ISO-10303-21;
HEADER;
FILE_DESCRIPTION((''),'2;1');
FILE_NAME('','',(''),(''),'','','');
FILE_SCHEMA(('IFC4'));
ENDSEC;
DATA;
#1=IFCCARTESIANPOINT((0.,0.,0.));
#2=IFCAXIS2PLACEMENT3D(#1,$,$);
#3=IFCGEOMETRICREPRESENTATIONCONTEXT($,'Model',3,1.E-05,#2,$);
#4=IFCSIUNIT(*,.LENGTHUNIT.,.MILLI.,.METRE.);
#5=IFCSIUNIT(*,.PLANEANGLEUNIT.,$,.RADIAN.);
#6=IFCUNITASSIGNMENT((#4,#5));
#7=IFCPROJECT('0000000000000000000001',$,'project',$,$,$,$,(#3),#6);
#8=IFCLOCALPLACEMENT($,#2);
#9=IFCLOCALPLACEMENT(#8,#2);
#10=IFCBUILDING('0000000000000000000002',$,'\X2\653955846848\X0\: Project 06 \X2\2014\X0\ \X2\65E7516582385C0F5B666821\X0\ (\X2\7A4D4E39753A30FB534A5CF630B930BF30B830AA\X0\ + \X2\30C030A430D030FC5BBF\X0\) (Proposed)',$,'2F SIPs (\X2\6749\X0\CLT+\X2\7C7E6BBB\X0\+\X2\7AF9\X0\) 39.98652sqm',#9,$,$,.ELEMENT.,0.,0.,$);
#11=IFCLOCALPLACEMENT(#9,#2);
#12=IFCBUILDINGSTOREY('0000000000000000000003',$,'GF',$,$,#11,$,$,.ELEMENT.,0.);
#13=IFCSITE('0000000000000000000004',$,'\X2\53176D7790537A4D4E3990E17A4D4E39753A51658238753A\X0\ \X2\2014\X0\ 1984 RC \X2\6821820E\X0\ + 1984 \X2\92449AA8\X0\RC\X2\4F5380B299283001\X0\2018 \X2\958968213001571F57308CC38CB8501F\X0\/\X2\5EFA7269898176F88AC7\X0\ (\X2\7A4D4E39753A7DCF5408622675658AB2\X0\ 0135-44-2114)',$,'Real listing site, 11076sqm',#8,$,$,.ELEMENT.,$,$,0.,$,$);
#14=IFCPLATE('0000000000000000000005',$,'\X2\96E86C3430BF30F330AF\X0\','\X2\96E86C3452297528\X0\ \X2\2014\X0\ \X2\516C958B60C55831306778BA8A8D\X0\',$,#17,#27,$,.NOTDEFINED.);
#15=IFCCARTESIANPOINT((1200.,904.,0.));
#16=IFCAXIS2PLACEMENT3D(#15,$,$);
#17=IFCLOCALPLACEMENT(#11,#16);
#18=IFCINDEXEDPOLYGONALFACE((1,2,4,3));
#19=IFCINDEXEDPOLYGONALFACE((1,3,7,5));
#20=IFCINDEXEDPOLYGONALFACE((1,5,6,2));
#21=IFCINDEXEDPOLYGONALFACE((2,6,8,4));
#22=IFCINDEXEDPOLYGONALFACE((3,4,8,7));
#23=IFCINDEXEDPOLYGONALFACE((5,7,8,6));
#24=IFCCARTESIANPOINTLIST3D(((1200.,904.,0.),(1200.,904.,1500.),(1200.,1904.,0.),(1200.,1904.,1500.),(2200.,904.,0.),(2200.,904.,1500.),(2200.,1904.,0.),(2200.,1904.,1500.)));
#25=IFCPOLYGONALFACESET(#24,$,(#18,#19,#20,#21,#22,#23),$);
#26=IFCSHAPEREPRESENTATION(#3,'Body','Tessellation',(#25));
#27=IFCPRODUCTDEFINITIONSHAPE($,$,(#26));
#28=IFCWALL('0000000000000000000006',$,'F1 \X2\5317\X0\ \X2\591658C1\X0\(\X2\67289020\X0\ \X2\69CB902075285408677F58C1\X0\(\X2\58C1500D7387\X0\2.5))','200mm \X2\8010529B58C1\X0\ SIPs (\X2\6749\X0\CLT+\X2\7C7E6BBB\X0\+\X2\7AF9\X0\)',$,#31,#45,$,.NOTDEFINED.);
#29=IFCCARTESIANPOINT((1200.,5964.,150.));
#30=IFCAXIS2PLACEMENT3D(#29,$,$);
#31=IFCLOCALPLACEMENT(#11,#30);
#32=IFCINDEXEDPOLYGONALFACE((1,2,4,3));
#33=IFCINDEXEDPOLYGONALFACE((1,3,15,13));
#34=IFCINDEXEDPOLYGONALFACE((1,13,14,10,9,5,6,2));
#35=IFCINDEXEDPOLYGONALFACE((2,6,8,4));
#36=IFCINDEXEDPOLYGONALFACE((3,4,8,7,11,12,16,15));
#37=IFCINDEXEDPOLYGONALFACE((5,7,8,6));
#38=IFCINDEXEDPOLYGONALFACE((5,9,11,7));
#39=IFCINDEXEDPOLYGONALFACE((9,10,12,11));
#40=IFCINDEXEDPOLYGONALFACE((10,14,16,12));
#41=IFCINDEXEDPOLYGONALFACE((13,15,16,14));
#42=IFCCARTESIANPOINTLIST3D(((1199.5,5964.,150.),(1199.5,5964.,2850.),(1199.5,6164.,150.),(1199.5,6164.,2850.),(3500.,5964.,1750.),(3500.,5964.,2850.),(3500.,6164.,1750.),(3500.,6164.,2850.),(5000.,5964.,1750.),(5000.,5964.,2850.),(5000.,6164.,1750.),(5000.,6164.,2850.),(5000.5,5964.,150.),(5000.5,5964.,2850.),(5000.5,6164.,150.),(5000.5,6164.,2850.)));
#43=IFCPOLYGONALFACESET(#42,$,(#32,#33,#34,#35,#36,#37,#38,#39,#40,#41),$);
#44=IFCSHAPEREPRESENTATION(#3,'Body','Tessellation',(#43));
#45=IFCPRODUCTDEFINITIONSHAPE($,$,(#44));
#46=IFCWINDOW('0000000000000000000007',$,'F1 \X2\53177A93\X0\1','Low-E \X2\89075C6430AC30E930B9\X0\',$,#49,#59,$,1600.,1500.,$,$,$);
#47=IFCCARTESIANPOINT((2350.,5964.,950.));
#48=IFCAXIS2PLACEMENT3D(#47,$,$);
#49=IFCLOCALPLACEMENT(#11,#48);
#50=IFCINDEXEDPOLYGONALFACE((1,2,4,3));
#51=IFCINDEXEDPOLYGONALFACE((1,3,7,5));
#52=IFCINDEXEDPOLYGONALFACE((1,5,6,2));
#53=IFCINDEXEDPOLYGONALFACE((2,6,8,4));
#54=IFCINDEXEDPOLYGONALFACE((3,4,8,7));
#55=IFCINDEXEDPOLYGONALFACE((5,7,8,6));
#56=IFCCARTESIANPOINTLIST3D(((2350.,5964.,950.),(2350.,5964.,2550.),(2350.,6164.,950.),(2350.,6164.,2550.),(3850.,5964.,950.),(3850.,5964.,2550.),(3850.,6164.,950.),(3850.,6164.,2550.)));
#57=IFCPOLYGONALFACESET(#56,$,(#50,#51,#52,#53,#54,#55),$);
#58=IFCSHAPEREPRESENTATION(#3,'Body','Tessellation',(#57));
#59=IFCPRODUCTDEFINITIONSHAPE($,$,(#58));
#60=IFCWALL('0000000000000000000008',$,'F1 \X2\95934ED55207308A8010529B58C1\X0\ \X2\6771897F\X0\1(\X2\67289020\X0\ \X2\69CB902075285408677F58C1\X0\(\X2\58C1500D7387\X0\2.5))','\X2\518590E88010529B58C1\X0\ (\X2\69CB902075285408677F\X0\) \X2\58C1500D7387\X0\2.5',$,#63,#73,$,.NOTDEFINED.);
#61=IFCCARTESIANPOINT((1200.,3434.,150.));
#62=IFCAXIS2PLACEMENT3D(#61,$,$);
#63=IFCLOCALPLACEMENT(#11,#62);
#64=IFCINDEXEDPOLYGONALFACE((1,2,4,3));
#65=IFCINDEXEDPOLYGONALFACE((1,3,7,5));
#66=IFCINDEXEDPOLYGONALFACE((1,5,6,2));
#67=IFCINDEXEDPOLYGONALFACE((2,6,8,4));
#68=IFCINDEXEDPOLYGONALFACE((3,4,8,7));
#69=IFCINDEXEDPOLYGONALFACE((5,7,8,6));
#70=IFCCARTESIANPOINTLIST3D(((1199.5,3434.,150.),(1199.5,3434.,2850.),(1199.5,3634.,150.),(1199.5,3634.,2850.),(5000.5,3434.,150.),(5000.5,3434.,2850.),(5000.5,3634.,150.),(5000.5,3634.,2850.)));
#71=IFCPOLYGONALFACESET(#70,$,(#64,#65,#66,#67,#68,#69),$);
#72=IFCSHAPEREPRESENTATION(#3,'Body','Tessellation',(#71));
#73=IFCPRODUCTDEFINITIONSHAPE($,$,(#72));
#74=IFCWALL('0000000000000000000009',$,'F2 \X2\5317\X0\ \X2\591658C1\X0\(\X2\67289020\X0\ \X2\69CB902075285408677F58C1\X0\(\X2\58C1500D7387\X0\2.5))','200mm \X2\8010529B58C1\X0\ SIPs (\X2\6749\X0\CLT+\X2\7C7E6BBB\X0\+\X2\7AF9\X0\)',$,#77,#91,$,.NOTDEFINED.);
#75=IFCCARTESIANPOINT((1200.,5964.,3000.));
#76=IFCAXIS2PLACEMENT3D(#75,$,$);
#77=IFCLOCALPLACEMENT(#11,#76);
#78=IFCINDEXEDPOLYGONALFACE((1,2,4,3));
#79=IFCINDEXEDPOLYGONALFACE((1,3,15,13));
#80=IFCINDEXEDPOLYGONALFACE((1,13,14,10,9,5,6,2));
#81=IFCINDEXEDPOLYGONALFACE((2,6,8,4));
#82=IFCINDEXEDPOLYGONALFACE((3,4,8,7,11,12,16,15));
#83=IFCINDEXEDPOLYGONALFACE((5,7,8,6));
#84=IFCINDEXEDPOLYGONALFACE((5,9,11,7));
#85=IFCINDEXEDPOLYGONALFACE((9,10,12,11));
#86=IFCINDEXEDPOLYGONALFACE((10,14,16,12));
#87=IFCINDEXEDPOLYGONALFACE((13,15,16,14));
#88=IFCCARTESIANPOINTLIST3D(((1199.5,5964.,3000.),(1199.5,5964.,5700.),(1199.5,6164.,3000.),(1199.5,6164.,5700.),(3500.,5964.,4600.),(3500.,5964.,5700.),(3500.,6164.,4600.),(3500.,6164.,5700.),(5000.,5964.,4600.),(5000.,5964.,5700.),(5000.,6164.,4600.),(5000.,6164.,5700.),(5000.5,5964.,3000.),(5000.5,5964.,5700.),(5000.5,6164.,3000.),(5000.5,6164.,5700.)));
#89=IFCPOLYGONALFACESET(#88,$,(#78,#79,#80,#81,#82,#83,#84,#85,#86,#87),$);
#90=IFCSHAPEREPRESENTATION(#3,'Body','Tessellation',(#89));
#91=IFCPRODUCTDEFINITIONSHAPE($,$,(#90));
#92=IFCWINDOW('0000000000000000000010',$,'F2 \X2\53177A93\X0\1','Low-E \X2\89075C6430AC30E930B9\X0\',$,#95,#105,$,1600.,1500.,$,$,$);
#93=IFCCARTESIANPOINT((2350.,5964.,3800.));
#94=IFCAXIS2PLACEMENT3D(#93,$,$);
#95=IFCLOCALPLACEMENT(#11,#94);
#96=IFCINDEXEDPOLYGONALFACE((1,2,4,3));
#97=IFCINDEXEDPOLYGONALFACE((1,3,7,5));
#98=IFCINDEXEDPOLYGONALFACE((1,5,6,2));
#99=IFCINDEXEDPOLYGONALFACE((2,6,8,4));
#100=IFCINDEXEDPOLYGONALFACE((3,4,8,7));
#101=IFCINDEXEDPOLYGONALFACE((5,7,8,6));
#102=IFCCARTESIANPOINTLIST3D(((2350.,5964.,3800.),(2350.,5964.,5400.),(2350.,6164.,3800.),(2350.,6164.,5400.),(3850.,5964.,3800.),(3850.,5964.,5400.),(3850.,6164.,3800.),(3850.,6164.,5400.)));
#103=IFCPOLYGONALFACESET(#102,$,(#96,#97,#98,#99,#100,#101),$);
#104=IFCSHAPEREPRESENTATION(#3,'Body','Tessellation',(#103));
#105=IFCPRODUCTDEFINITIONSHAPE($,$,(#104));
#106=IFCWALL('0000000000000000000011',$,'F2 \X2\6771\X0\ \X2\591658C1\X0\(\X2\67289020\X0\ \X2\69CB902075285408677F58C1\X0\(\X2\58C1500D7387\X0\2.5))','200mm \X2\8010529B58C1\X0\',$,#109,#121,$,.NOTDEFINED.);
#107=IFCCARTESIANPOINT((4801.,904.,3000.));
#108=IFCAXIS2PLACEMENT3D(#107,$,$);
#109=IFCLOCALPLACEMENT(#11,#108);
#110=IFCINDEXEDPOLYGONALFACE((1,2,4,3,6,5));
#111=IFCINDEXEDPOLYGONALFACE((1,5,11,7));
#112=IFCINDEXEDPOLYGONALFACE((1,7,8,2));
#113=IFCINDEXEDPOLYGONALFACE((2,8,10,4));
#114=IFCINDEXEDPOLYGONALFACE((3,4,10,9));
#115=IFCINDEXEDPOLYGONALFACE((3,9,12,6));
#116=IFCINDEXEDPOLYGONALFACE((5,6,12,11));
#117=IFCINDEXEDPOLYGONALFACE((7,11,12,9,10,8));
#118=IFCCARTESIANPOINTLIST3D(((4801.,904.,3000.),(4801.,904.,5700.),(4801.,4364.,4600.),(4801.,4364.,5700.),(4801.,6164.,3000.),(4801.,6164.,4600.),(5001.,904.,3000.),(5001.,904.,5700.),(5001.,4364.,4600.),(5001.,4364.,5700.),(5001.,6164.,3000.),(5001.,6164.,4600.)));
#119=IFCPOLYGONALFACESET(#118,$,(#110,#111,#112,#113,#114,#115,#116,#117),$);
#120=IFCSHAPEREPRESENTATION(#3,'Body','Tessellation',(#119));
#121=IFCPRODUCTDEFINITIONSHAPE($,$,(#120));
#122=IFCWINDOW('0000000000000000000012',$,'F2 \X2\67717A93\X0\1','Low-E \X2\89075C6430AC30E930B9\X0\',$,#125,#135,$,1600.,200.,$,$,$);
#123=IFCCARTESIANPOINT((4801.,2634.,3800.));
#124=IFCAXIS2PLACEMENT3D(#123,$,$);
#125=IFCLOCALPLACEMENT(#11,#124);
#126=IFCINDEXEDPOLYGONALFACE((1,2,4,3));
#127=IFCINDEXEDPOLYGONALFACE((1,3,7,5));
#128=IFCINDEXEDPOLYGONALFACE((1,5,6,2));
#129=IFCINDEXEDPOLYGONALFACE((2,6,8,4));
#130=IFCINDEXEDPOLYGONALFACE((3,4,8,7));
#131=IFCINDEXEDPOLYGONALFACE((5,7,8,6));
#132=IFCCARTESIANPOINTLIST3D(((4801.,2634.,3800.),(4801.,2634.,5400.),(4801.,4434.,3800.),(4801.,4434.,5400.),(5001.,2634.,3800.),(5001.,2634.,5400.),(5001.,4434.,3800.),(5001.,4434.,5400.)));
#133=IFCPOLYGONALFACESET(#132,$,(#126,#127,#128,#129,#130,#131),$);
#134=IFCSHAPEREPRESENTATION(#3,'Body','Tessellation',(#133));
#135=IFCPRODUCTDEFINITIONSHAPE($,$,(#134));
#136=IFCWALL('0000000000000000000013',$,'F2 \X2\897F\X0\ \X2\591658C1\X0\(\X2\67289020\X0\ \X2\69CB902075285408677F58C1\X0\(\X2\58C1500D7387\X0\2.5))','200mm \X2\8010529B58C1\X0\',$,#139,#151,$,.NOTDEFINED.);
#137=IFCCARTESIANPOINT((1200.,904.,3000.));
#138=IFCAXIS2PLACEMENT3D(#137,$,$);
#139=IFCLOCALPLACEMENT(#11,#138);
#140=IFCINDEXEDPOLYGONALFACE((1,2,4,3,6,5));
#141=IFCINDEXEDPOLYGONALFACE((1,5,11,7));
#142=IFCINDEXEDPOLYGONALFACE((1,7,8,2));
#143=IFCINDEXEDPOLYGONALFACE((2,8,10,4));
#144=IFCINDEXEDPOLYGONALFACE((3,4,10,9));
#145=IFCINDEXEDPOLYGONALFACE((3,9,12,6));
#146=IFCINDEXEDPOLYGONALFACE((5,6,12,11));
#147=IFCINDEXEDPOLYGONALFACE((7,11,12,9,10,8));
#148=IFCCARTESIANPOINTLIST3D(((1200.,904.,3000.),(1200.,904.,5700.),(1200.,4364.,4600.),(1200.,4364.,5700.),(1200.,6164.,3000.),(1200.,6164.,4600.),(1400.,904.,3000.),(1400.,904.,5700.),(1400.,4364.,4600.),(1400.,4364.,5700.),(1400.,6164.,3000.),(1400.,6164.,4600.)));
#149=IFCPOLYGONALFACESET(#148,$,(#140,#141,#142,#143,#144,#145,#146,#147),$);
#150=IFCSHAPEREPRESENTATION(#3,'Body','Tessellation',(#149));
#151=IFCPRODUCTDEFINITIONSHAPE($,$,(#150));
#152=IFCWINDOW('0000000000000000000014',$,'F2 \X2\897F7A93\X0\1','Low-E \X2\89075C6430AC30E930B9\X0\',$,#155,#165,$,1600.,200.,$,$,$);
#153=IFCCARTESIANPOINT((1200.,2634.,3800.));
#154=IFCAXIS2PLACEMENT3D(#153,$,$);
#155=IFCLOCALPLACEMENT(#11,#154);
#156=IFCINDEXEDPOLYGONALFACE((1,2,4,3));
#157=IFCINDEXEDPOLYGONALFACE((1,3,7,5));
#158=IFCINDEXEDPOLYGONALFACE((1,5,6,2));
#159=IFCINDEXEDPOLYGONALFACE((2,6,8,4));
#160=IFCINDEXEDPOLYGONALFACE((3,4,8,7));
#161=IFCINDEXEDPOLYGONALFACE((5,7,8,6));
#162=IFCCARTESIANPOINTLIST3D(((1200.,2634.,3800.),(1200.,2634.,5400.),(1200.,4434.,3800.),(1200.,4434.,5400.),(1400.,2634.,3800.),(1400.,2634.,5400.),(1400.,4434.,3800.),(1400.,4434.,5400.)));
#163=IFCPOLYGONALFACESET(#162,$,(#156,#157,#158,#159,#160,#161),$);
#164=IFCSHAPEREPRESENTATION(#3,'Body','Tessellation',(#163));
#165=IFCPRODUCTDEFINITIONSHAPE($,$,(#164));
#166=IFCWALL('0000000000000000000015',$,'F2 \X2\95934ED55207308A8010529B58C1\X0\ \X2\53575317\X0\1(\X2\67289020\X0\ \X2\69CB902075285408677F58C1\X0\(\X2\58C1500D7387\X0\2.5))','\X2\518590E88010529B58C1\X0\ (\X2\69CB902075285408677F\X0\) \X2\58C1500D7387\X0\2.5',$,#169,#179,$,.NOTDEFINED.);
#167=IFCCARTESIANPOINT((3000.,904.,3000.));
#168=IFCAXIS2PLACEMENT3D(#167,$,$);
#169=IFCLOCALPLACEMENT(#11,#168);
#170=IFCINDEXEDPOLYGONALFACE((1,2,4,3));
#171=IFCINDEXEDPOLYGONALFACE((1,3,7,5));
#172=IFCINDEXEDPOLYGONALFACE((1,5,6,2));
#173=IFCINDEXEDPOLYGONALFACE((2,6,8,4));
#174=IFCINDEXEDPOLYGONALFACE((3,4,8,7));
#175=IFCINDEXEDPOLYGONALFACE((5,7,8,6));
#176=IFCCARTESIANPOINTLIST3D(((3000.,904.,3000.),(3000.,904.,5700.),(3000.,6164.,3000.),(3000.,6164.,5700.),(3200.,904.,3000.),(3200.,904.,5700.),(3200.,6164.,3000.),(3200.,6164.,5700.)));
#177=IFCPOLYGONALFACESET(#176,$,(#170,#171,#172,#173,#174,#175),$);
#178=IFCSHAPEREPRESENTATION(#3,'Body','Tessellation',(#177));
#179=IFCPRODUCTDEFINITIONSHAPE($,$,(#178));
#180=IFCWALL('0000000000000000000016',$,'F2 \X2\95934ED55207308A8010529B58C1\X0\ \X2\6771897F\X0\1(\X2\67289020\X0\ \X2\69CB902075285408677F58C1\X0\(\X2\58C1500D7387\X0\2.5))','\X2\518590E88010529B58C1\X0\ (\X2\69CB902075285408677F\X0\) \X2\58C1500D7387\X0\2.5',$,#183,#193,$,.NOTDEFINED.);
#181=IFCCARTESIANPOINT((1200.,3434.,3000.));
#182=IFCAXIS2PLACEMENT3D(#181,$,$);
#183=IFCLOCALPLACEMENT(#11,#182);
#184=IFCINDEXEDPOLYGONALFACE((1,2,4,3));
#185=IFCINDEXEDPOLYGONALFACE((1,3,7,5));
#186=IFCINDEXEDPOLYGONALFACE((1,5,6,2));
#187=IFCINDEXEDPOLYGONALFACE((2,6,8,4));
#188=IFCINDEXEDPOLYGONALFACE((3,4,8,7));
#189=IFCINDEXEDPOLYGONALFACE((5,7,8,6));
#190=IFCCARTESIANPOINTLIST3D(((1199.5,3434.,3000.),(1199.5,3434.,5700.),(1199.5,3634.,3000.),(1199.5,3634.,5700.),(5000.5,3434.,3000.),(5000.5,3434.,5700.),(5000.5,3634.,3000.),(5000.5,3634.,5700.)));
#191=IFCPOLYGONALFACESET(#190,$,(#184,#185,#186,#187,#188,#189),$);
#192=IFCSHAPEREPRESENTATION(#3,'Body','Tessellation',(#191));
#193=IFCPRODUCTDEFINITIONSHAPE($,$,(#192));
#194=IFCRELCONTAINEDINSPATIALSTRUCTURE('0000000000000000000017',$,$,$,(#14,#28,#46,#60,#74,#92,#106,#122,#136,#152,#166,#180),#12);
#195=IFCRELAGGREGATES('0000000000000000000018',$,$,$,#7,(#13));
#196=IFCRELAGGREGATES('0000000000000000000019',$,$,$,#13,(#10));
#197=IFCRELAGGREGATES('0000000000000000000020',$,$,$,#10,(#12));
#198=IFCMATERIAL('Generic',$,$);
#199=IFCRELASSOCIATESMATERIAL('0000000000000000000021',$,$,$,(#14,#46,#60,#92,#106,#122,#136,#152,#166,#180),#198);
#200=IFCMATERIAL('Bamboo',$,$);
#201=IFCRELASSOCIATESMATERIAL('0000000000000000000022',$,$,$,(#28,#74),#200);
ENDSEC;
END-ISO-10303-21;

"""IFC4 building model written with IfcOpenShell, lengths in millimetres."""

from ifc_helpers import new_model, si_unit, frame, frame_2d, origin, place, context, project, spatial, rectangle, extrude, material, element, fill, save


model = new_model("IFC4")

# Units and contexts
model_context = context("Model", 3, precision=1e-05, world=origin())
ifc_project = project(units=[si_unit("LENGTHUNIT", "METRE", prefix="MILLI"), si_unit("PLANEANGLEUNIT", "RADIAN")], contexts=[model_context])

# Site, building, storey
site_placement = place(None, origin())
site = spatial("IfcSite", under=ifc_project, at=site_placement, Name="北海道積丹郡積丹町入舸町 — 1984 RC 校舎 + 1984 鉄骨RC体育館、2018 閉校、土地賃貸借/建物要相談 (積丹町総合戦略課 0135-44-2114)", ObjectType="Real listing site, 11076sqm", CompositionType="ELEMENT", RefElevation=0.0)
building_placement = place(site_placement, origin())
building = spatial("IfcBuilding", under=site, at=building_placement, Name="改善案: Project 06 — 旧入舸小学校 (積丹町・半島スタジオ + ダイバー宿) (Proposed)", ObjectType="2F SIPs (杉CLT+籾殻+竹) 39.98652sqm", CompositionType="ELEMENT", ElevationOfRefHeight=0.0, ElevationOfTerrain=0.0)
storey_placement = place(building_placement, origin())
storey = spatial("IfcBuildingStorey", under=building, at=storey_placement, Name="GF", CompositionType="ELEMENT", Elevation=0.0)

# Plate
ifc_material_1 = material(Name="Generic")
plate_placement = place(storey_placement, frame((1200.0, 904.0, 0.0)))
element("IfcPlate", 1, at=plate_placement, inside=storey, material=ifc_material_1, Name="雨水タンク", Description="雨水利用 — 公開情報で確認", PredefinedType="NOTDEFINED", context=model_context, shape_type="SweptSolid", body=[
    extrude(rectangle(XDim=1000.0, YDim=1000.0, at=frame_2d((500.0, 500.0))), frame((1200.0, 904.0, 0.0)), (0.0, 0.0, 1.0), 1500.0),
])

# Wall, opening, window
ifc_material_2 = material(Name="Bamboo")
wall_1_placement = place(storey_placement, frame((1200.0, 5964.0, 150.0)))
wall_1 = element("IfcWall", 2, at=wall_1_placement, inside=storey, material=ifc_material_2, Name="F1 北 外壁(木造 構造用合板壁(壁倍率2.5))", Description="200mm 耐力壁 SIPs (杉CLT+籾殻+竹)", PredefinedType="NOTDEFINED", context=model_context, shape_type="SweptSolid", body=[
    extrude(rectangle(XDim=3801.0, YDim=200.0, at=frame_2d((1900.0, 100.0))), frame((1200.0, 5964.0, 150.0)), (0.0, 0.0, 1.0), 2700.0),
])
opening_1_placement = place(storey_placement, frame((2350.0, 5964.0, 950.0)))
opening_1 = element("IfcOpeningElement", 3, at=opening_1_placement, cuts=wall_1, PredefinedType="NOTDEFINED", context=model_context, shape_type="SweptSolid", body=[
    extrude(rectangle(XDim=1500.0, YDim=200.0, at=frame_2d((750.0, 100.0))), frame((2350.0, 5964.0, 950.0)), (0.0, 0.0, 1.0), 1600.0),
])
window_1_placement = place(storey_placement, frame((2350.0, 5964.0, 950.0)))
window_1 = element("IfcWindow", 4, at=window_1_placement, inside=storey, material=ifc_material_1, Name="F1 北窓1", Description="Low-E 複層ガラス", OverallHeight=1600.0, OverallWidth=1500.0, context=model_context, shape_type="SweptSolid", body=[
    extrude(rectangle(XDim=1500.0, YDim=200.0, at=frame_2d((750.0, 100.0))), frame((2350.0, 5964.0, 950.0)), (0.0, 0.0, 1.0), 1600.0),
])
fill(opening_1, window_1)

# Wall
wall_2_placement = place(storey_placement, frame((1200.0, 3434.0, 150.0)))
element("IfcWall", 5, at=wall_2_placement, inside=storey, material=ifc_material_1, Name="F1 間仕切り耐力壁 東西1(木造 構造用合板壁(壁倍率2.5))", Description="内部耐力壁 (構造用合板) 壁倍率2.5", PredefinedType="NOTDEFINED", context=model_context, shape_type="SweptSolid", body=[
    extrude(rectangle(XDim=3801.0, YDim=200.0, at=frame_2d((1900.0, 100.0))), frame((1200.0, 3434.0, 150.0)), (0.0, 0.0, 1.0), 2700.0),
])

# Walls, openings, windows
wall_3_placement = place(storey_placement, frame((1200.0, 5964.0, 3000.0)))
wall_3 = element("IfcWall", 6, at=wall_3_placement, inside=storey, material=ifc_material_2, Name="F2 北 外壁(木造 構造用合板壁(壁倍率2.5))", Description="200mm 耐力壁 SIPs (杉CLT+籾殻+竹)", PredefinedType="NOTDEFINED", context=model_context, shape_type="SweptSolid", body=[
    extrude(rectangle(XDim=3801.0, YDim=200.0, at=frame_2d((1900.0, 100.0))), frame((1200.0, 5964.0, 3000.0)), (0.0, 0.0, 1.0), 2700.0),
])
opening_2_placement = place(storey_placement, frame((2350.0, 5964.0, 3800.0)))
opening_2 = element("IfcOpeningElement", 7, at=opening_2_placement, cuts=wall_3, PredefinedType="NOTDEFINED", context=model_context, shape_type="SweptSolid", body=[
    extrude(rectangle(XDim=1500.0, YDim=200.0, at=frame_2d((750.0, 100.0))), frame((2350.0, 5964.0, 3800.0)), (0.0, 0.0, 1.0), 1600.0),
])
window_2_placement = place(storey_placement, frame((2350.0, 5964.0, 3800.0)))
window_2 = element("IfcWindow", 8, at=window_2_placement, inside=storey, material=ifc_material_1, Name="F2 北窓1", Description="Low-E 複層ガラス", OverallHeight=1600.0, OverallWidth=1500.0, context=model_context, shape_type="SweptSolid", body=[
    extrude(rectangle(XDim=1500.0, YDim=200.0, at=frame_2d((750.0, 100.0))), frame((2350.0, 5964.0, 3800.0)), (0.0, 0.0, 1.0), 1600.0),
])
fill(opening_2, window_2)
wall_4_placement = place(storey_placement, frame((4801.0, 904.0, 3000.0)))
wall_4 = element("IfcWall", 9, at=wall_4_placement, inside=storey, material=ifc_material_1, Name="F2 東 外壁(木造 構造用合板壁(壁倍率2.5))", Description="200mm 耐力壁", PredefinedType="NOTDEFINED", context=model_context, shape_type="SweptSolid", body=[
    extrude(rectangle(XDim=200.0, YDim=5260.0, at=frame_2d((100.0, 2630.0))), frame((4801.0, 904.0, 3000.0)), (0.0, 0.0, 1.0), 2700.0),
])
opening_3_placement = place(storey_placement, frame((4801.0, 2634.0, 3800.0)))
opening_3 = element("IfcOpeningElement", 10, at=opening_3_placement, cuts=wall_4, PredefinedType="NOTDEFINED", context=model_context, shape_type="SweptSolid", body=[
    extrude(rectangle(XDim=200.0, YDim=1800.0, at=frame_2d((100.0, 900.0))), frame((4801.0, 2634.0, 3800.0)), (0.0, 0.0, 1.0), 1600.0),
])
window_3_placement = place(storey_placement, frame((4801.0, 2634.0, 3800.0)))
window_3 = element("IfcWindow", 11, at=window_3_placement, inside=storey, material=ifc_material_1, Name="F2 東窓1", Description="Low-E 複層ガラス", OverallHeight=1600.0, OverallWidth=200.0, context=model_context, shape_type="SweptSolid", body=[
    extrude(rectangle(XDim=200.0, YDim=1800.0, at=frame_2d((100.0, 900.0))), frame((4801.0, 2634.0, 3800.0)), (0.0, 0.0, 1.0), 1600.0),
])
fill(opening_3, window_3)
wall_5_placement = place(storey_placement, frame((1200.0, 904.0, 3000.0)))
wall_5 = element("IfcWall", 12, at=wall_5_placement, inside=storey, material=ifc_material_1, Name="F2 西 外壁(木造 構造用合板壁(壁倍率2.5))", Description="200mm 耐力壁", PredefinedType="NOTDEFINED", context=model_context, shape_type="SweptSolid", body=[
    extrude(rectangle(XDim=200.0, YDim=5260.0, at=frame_2d((100.0, 2630.0))), frame((1200.0, 904.0, 3000.0)), (0.0, 0.0, 1.0), 2700.0),
])
opening_4_placement = place(storey_placement, frame((1200.0, 2634.0, 3800.0)))
opening_4 = element("IfcOpeningElement", 13, at=opening_4_placement, cuts=wall_5, PredefinedType="NOTDEFINED", context=model_context, shape_type="SweptSolid", body=[
    extrude(rectangle(XDim=200.0, YDim=1800.0, at=frame_2d((100.0, 900.0))), frame((1200.0, 2634.0, 3800.0)), (0.0, 0.0, 1.0), 1600.0),
])
window_4_placement = place(storey_placement, frame((1200.0, 2634.0, 3800.0)))
window_4 = element("IfcWindow", 14, at=window_4_placement, inside=storey, material=ifc_material_1, Name="F2 西窓1", Description="Low-E 複層ガラス", OverallHeight=1600.0, OverallWidth=200.0, context=model_context, shape_type="SweptSolid", body=[
    extrude(rectangle(XDim=200.0, YDim=1800.0, at=frame_2d((100.0, 900.0))), frame((1200.0, 2634.0, 3800.0)), (0.0, 0.0, 1.0), 1600.0),
])
fill(opening_4, window_4)

# Walls
wall_6_placement = place(storey_placement, frame((3000.0, 904.0, 3000.0)))
element("IfcWall", 15, at=wall_6_placement, inside=storey, material=ifc_material_1, Name="F2 間仕切り耐力壁 南北1(木造 構造用合板壁(壁倍率2.5))", Description="内部耐力壁 (構造用合板) 壁倍率2.5", PredefinedType="NOTDEFINED", context=model_context, shape_type="SweptSolid", body=[
    extrude(rectangle(XDim=200.0, YDim=5260.0, at=frame_2d((100.0, 2630.0))), frame((3000.0, 904.0, 3000.0)), (0.0, 0.0, 1.0), 2700.0),
])
wall_7_placement = place(storey_placement, frame((1200.0, 3434.0, 3000.0)))
element("IfcWall", 16, at=wall_7_placement, inside=storey, material=ifc_material_1, Name="F2 間仕切り耐力壁 東西1(木造 構造用合板壁(壁倍率2.5))", Description="内部耐力壁 (構造用合板) 壁倍率2.5", PredefinedType="NOTDEFINED", context=model_context, shape_type="SweptSolid", body=[
    extrude(rectangle(XDim=3801.0, YDim=200.0, at=frame_2d((1900.0, 100.0))), frame((1200.0, 3434.0, 3000.0)), (0.0, 0.0, 1.0), 2700.0),
])

save(model, "model.ifc")
